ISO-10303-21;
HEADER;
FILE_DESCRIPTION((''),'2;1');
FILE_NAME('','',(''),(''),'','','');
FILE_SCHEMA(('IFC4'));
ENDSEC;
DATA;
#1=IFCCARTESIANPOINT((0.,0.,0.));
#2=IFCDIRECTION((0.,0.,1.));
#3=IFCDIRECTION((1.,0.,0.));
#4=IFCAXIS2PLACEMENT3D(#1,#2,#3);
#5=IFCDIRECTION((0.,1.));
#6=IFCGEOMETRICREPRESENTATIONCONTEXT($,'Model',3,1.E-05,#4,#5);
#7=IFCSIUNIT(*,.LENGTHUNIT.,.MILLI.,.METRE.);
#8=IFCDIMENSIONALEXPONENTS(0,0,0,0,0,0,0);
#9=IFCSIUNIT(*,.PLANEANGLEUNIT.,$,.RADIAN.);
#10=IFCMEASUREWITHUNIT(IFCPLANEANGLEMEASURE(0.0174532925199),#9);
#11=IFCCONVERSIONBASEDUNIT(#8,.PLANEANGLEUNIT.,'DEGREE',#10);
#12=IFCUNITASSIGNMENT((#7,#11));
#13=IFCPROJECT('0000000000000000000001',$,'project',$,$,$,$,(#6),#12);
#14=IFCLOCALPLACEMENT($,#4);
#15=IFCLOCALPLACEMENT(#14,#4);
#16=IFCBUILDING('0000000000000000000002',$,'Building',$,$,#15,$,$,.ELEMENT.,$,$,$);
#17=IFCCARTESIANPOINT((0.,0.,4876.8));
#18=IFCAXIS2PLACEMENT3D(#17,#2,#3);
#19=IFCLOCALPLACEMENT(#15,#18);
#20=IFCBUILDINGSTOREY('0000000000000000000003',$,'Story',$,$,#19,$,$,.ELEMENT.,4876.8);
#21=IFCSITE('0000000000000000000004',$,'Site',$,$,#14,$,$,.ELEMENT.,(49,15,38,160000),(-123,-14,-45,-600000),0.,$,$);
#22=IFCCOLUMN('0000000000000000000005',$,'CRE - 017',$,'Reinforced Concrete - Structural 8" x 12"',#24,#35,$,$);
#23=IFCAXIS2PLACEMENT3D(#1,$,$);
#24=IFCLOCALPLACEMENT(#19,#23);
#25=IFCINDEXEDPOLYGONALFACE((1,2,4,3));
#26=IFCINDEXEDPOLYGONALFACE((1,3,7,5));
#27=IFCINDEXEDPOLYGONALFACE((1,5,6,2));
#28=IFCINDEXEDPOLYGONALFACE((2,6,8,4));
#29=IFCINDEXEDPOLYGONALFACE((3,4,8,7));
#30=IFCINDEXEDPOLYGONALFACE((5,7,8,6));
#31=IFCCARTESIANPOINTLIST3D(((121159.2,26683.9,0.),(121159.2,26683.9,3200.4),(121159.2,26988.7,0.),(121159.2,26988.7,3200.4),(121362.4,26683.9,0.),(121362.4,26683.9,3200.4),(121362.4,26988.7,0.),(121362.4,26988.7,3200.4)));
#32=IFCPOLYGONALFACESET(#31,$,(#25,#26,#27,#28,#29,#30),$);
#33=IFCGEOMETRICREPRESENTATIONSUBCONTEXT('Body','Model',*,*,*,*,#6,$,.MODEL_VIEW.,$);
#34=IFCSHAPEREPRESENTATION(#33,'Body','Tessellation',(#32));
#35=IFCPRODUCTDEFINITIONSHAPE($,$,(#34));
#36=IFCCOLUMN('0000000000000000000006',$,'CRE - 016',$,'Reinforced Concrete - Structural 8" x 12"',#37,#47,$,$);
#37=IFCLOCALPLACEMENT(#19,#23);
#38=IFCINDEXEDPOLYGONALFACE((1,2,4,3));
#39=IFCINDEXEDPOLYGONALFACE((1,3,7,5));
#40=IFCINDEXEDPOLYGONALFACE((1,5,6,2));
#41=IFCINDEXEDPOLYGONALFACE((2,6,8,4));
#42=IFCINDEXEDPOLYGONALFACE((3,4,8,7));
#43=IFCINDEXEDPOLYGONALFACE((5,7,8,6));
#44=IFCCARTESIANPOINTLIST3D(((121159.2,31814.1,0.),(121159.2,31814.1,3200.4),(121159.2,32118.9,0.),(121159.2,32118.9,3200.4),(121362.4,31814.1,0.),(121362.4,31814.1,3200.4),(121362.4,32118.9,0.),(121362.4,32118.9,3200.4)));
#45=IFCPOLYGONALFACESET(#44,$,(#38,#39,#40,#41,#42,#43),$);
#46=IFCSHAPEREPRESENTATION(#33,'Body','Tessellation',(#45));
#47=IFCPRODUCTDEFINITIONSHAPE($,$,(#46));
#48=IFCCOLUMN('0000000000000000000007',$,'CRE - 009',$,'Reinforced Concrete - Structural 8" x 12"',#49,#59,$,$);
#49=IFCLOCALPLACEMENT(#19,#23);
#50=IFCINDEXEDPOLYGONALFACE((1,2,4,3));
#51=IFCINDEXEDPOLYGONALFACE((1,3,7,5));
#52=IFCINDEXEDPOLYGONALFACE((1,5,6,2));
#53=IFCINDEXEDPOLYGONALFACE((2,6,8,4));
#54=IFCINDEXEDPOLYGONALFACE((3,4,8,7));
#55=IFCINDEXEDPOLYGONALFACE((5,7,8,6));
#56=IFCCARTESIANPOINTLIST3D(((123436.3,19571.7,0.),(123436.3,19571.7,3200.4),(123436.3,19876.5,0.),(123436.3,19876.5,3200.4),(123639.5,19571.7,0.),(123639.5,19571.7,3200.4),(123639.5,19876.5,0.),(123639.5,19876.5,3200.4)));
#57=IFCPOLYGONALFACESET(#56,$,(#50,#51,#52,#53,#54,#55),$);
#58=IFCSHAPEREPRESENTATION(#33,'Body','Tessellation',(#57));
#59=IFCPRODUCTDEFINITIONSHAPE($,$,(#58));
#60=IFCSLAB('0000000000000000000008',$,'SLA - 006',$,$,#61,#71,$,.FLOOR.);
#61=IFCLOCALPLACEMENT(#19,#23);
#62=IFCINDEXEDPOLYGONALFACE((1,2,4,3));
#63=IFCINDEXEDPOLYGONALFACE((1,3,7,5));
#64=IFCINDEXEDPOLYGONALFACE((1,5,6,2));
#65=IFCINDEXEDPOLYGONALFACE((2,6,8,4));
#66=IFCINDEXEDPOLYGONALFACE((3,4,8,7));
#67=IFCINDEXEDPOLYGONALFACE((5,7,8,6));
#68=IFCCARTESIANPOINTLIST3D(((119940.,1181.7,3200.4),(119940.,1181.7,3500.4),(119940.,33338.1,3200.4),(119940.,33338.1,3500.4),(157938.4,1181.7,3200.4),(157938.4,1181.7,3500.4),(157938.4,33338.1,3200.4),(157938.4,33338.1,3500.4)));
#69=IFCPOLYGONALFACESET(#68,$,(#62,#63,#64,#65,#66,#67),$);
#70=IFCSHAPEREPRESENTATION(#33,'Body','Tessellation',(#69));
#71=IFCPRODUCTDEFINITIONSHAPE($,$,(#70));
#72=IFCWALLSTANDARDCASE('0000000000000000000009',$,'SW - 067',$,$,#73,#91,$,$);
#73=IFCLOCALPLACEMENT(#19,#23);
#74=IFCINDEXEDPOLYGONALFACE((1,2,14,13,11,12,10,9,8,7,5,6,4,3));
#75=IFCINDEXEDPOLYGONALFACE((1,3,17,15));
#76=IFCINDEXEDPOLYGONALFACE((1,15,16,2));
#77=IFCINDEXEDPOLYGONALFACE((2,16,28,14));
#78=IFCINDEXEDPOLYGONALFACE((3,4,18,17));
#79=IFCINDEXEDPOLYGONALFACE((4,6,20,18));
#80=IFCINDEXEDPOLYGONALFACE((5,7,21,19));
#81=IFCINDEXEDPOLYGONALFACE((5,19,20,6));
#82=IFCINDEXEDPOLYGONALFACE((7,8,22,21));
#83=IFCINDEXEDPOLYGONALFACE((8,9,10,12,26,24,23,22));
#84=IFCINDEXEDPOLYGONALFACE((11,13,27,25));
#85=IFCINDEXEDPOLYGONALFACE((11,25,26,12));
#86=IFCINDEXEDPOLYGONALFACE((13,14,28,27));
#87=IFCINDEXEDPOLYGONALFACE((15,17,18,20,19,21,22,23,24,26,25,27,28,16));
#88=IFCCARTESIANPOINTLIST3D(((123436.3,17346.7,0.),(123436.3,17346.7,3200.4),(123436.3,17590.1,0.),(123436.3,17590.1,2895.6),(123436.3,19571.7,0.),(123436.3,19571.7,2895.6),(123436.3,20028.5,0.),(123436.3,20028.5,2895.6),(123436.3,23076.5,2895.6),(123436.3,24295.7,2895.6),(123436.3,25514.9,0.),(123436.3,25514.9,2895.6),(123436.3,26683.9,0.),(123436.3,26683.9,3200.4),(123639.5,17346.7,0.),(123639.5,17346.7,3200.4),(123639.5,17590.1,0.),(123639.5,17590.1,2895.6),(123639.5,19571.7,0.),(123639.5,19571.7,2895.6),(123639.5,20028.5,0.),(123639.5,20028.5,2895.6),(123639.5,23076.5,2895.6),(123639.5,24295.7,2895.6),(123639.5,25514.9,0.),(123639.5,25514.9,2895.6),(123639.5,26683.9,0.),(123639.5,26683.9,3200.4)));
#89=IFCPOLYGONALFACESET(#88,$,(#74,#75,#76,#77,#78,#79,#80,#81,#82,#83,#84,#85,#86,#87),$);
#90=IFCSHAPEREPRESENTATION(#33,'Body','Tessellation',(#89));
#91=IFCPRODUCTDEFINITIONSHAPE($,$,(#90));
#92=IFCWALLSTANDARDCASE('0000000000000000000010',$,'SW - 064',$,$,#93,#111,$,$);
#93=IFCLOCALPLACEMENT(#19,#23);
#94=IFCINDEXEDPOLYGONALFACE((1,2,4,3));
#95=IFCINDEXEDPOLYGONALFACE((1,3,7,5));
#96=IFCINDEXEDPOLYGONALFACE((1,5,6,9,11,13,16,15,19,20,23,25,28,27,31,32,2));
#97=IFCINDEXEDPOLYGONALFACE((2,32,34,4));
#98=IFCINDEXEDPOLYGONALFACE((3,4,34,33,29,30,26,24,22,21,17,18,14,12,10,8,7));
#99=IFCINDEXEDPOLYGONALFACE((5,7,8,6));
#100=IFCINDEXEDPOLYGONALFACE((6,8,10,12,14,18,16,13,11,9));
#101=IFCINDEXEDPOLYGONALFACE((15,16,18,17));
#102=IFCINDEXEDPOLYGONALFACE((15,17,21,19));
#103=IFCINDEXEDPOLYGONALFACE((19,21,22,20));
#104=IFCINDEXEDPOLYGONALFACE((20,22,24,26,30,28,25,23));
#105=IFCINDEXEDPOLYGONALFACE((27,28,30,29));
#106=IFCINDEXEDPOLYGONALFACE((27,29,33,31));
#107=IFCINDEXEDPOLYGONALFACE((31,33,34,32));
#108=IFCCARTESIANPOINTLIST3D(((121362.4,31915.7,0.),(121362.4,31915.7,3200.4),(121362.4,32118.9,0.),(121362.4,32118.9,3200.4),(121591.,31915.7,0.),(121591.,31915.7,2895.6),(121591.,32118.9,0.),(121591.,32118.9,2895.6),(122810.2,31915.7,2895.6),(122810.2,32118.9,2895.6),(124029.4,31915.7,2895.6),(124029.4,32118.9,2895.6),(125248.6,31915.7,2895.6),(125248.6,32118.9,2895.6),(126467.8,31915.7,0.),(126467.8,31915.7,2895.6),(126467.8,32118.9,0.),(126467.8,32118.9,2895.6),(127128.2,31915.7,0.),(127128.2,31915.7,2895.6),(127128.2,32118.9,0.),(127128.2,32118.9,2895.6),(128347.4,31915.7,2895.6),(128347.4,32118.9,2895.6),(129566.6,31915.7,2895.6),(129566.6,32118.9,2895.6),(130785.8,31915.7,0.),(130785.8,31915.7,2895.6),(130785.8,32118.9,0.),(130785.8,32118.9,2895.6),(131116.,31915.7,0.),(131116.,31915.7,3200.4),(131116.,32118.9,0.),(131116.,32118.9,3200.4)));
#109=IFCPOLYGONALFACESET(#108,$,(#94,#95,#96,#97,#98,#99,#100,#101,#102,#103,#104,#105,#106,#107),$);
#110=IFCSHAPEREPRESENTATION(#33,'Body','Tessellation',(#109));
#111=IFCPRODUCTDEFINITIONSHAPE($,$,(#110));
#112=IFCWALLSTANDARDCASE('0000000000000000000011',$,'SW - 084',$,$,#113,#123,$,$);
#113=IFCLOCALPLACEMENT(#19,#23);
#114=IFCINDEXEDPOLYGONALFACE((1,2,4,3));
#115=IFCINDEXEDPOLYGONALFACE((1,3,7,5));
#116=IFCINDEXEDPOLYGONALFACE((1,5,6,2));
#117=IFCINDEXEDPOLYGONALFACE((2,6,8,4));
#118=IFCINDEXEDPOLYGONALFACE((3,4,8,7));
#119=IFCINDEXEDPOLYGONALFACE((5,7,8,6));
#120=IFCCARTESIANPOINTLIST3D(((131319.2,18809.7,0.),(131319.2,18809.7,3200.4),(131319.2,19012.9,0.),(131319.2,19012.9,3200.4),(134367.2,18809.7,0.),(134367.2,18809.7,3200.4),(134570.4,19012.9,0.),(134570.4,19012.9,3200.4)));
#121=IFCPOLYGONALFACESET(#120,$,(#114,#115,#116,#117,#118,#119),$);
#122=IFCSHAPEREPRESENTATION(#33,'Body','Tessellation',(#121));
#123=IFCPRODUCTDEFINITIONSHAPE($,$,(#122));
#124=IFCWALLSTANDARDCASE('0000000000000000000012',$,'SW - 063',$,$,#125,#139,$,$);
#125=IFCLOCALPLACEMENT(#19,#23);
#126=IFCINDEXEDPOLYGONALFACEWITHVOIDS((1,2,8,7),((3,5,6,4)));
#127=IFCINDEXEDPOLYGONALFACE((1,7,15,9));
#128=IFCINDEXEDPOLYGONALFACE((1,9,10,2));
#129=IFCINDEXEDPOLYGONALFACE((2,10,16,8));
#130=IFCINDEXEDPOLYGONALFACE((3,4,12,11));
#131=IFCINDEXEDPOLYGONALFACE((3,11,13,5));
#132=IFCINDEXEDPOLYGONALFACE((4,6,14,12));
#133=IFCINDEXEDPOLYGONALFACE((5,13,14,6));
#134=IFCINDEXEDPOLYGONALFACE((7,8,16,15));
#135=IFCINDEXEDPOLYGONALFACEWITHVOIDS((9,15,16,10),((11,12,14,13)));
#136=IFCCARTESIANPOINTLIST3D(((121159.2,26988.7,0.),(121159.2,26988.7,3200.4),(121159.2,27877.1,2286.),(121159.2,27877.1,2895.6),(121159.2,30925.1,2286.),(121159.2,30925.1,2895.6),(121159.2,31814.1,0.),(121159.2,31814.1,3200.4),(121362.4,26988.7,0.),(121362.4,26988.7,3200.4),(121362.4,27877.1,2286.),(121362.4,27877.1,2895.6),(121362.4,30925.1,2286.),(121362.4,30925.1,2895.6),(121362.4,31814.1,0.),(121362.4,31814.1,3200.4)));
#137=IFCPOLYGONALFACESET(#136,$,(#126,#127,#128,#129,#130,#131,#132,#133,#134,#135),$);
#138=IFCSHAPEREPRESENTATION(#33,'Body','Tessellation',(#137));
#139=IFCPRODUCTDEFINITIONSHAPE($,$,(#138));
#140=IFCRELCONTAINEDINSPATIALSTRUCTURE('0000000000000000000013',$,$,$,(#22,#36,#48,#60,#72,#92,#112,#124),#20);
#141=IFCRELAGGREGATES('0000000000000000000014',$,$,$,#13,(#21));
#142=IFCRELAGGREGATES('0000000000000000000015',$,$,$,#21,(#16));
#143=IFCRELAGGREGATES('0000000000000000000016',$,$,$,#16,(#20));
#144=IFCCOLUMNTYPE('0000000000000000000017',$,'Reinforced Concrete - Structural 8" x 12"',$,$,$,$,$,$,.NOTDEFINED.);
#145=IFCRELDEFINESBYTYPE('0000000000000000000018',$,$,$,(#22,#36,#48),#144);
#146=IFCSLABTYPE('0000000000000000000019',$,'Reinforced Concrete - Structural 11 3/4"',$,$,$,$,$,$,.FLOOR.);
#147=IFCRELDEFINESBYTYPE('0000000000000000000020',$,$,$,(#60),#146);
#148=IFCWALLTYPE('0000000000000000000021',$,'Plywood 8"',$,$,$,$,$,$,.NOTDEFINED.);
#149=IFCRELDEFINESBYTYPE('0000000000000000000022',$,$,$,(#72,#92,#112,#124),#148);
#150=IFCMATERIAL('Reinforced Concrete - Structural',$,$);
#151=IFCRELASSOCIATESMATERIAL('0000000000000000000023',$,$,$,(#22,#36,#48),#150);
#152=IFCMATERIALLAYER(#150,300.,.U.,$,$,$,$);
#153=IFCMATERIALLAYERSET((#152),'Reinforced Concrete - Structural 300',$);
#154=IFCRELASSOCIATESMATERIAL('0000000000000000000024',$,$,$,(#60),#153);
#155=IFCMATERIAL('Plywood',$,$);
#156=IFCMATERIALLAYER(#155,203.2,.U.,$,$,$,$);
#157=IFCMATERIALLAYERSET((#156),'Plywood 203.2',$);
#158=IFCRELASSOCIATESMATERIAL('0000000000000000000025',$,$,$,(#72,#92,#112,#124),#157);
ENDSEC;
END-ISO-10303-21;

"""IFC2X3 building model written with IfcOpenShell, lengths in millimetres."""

from ifc_helpers import new_model, entity, si_unit, converted_unit, direction, frame, origin_with_axes, origin_2d_with_axis, place, context, subcontext, project, spatial, polyline, rectangle, outline, extrude, material, layer, layer_set, layer_usage, type_object, element, save


model = new_model("IFC2X3")

# Units and contexts
model_context = context("Model", 3, precision=1e-05, world=origin_with_axes(), true_north=direction((0.0, 1.0)))
body_context = subcontext(model_context, "Body", "Model", "MODEL_VIEW")
ifc_project = project(units=[si_unit("LENGTHUNIT", "METRE", prefix="MILLI"), converted_unit("PLANEANGLEUNIT", "DEGREE", entity("IfcPlaneAngleMeasure", 0.0174532925199), si_unit("PLANEANGLEUNIT", "RADIAN"), dimensions=[0, 0, 0, 0, 0, 0, 0])], contexts=[model_context])

# Site, building, storey
site_placement = place(None, origin_with_axes())
site = spatial("IfcSite", under=ifc_project, at=site_placement, Name="Site", CompositionType="ELEMENT", RefLatitude=(49, 15, 38, 160000), RefLongitude=(-123, -14, -45, -600000), RefElevation=0.0)
building_placement = place(site_placement, origin_with_axes())
building = spatial("IfcBuilding", under=site, at=building_placement, Name="Building", CompositionType="ELEMENT")
storey_placement = place(building_placement, frame((0.0, 0.0, 4876.8), z_axis=(0.0, 0.0, 1.0), x_axis=(1.0, 0.0, 0.0)))
storey = spatial("IfcBuildingStorey", under=building, at=storey_placement, Name="Story", CompositionType="ELEMENT", Elevation=4876.8)

# Columns
ifc_material_1 = material(Name="Reinforced Concrete - Structural")
column_type = type_object("IfcColumnType", Name="Reinforced Concrete - Structural 8\" x 12\"", PredefinedType="NOTDEFINED")
for number, where, z_axis, x_axis, name in (
    (1, (121260.8, 26836.3, 0.0), (0.0, 0.0, 1.0), (1.0, 0.0, 0.0), "CRE - 017"),
    (2, (121260.8, 31966.5, 0.0), (0.0, 0.0, 1.0), (1.0, 0.0, 0.0), "CRE - 016"),
    (3, (123537.9, 19724.1, 0.0), (0.0, 0.0, 1.0), (1.0, 0.0, 0.0), "CRE - 009"),
):
    element("IfcColumn", number, at=place(storey_placement, frame(where, z_axis=z_axis, x_axis=x_axis)), inside=storey, type_object=column_type, material=ifc_material_1, Name=name, ObjectType="Reinforced Concrete - Structural 8\" x 12\"", context=body_context, shape_type="SweptSolid", body=[
        extrude(rectangle(XDim=203.2, YDim=304.8, at=origin_2d_with_axis()), origin_with_axes(), (0.0, 0.0, 1.0), 3200.4),
    ])

# Slab
ifc_layer_1 = layer(ifc_material_1, 300.0, ventilated="UNKNOWN")
ifc_layer_set_1 = layer_set([ifc_layer_1], Name="Reinforced Concrete - Structural 300")
ifc_layer_usage_1 = layer_usage(ifc_layer_set_1, "AXIS3", "NEGATIVE", 300.0)
slab_type = type_object("IfcSlabType", Name="Reinforced Concrete - Structural 11 3/4\"", PredefinedType="FLOOR")
slab_placement = place(storey_placement, frame((119940.0, 33338.1, 3500.4), z_axis=(0.0, 0.0, 1.0), x_axis=(1.0, 0.0, 0.0)))
element("IfcSlab", 4, at=slab_placement, inside=storey, type_object=slab_type, material=ifc_layer_usage_1, Name="SLA - 006", PredefinedType="FLOOR", context=body_context, shape_type="SweptSolid", body=[
    extrude(outline(polyline([(0.0, 0.0), (0.0, -32156.4), (37998.4, -32156.4), (37998.4, 0.0), (0.0, 0.0)])), frame((0.0, 0.0, -300.0), z_axis=(0.0, 0.0, 1.0), x_axis=(1.0, 0.0, 0.0)), (0.0, 0.0, 1.0), 300.0),
])

# Walls, openings
ifc_material_2 = material(Name="Plywood")
ifc_layer_2 = layer(ifc_material_2, 203.2, ventilated="UNKNOWN")
ifc_layer_set_2 = layer_set([ifc_layer_2], Name="Plywood 203.2")
ifc_layer_usage_2 = layer_usage(ifc_layer_set_2, "AXIS2", "NEGATIVE", 0.0)
wall_type_1 = type_object("IfcWallType", Name="Plywood 8\"", PredefinedType="NOTDEFINED")
wall_1_placement = place(storey_placement, frame((123639.5, 26887.1, 0.0), z_axis=(0.0, 0.0, 1.0), x_axis=(0.0, -1.0, 0.0)))
wall_1 = element("IfcWallStandardCase", 5, at=wall_1_placement, inside=storey, type_object=wall_type_1, material=ifc_layer_usage_2, Name="SW - 067", context=body_context, shape_type="SweptSolid", body=[
    extrude(outline(polyline([(203.2, -203.2), (9540.4, -203.2), (9540.4, 0.0), (203.2, 0.0), (203.2, -203.2)])), origin_with_axes(), (0.0, 0.0, 1.0), 3200.4),
])
opening_1_placement = place(wall_1_placement, frame((1981.7, 0.0, 0.0), z_axis=(0.0, 0.0, 1.0), x_axis=(1.0, 0.0, 0.0)))
element("IfcOpeningElement", 6, at=opening_1_placement, cuts=wall_1, context=body_context, shape_type="SweptSolid", body=[
    extrude(rectangle(XDim=1219.2, YDim=2895.6, at=origin_2d_with_axis()), frame((0.0, 203.2, 1447.8), z_axis=(0.0, -1.0, 0.0), x_axis=(-1.0, 0.0, 0.0)), (0.0, 0.0, 1.0), 609.6),
])
opening_2_placement = place(wall_1_placement, frame((3200.9, 0.0, 0.0), z_axis=(0.0, 0.0, 1.0), x_axis=(1.0, 0.0, 0.0)))
element("IfcOpeningElement", 7, at=opening_2_placement, cuts=wall_1, context=body_context, shape_type="SweptSolid", body=[
    extrude(rectangle(XDim=1219.2, YDim=2895.6, at=origin_2d_with_axis()), frame((0.0, 203.2, 1447.8), z_axis=(0.0, -1.0, 0.0), x_axis=(-1.0, 0.0, 0.0)), (0.0, 0.0, 1.0), 609.6),
])
opening_3_placement = place(wall_1_placement, frame((8306.2, 0.0, 0.0), z_axis=(0.0, 0.0, 1.0), x_axis=(1.0, 0.0, 0.0)))
element("IfcOpeningElement", 8, at=opening_3_placement, cuts=wall_1, context=body_context, shape_type="SweptSolid", body=[
    extrude(rectangle(XDim=1981.5, YDim=2895.6, at=origin_2d_with_axis()), frame((0.0, 203.2, 1447.8), z_axis=(0.0, -1.0, 0.0), x_axis=(-1.0, 0.0, 0.0)), (0.0, 0.0, 1.0), 609.6),
])
opening_4_placement = place(wall_1_placement, frame((5334.5, 0.0, 0.0), z_axis=(0.0, 0.0, 1.0), x_axis=(1.0, 0.0, 0.0)))
element("IfcOpeningElement", 9, at=opening_4_placement, cuts=wall_1, context=body_context, shape_type="SweptSolid", body=[
    extrude(rectangle(XDim=3048.0, YDim=2895.6, at=origin_2d_with_axis()), frame((0.0, 203.2, 1447.8), z_axis=(0.0, -1.0, 0.0), x_axis=(-1.0, 0.0, 0.0)), (0.0, 0.0, 1.0), 609.6),
])
ifc_layer_usage_3 = layer_usage(ifc_layer_set_2, "AXIS2", "POSITIVE", 0.0)
wall_2_placement = place(storey_placement, frame((121362.4, 31915.7, 0.0), z_axis=(0.0, 0.0, 1.0), x_axis=(1.0, 0.0, 0.0)))
wall_2 = element("IfcWallStandardCase", 10, at=wall_2_placement, inside=storey, type_object=wall_type_1, material=ifc_layer_usage_3, Name="SW - 064", context=body_context, shape_type="SweptSolid", body=[
    extrude(outline(polyline([(0.0, 0.0), (9753.6, 0.0), (9753.6, 203.2), (0.0, 203.2), (0.0, 0.0)])), origin_with_axes(), (0.0, 0.0, 1.0), 3200.4),
])
opening_5_placement = place(wall_2_placement, frame((8813.8, 0.0, 0.0), z_axis=(0.0, 0.0, 1.0), x_axis=(1.0, 0.0, 0.0)))
element("IfcOpeningElement", 11, at=opening_5_placement, cuts=wall_2, context=body_context, shape_type="SweptSolid", body=[
    extrude(rectangle(XDim=1219.2, YDim=2895.6, at=origin_2d_with_axis()), frame((0.0, -203.2, 1447.8), z_axis=(0.0, -1.0, 0.0), x_axis=(-1.0, 0.0, 0.0)), (0.0, 0.0, -1.0), 609.6),
])
opening_6_placement = place(wall_2_placement, frame((7594.6, 0.0, 0.0), z_axis=(0.0, 0.0, 1.0), x_axis=(1.0, 0.0, 0.0)))
element("IfcOpeningElement", 12, at=opening_6_placement, cuts=wall_2, context=body_context, shape_type="SweptSolid", body=[
    extrude(rectangle(XDim=1219.2, YDim=2895.6, at=origin_2d_with_axis()), frame((0.0, -203.2, 1447.8), z_axis=(0.0, -1.0, 0.0), x_axis=(-1.0, 0.0, 0.0)), (0.0, 0.0, -1.0), 609.6),
])
opening_7_placement = place(wall_2_placement, frame((6375.4, 0.0, 0.0), z_axis=(0.0, 0.0, 1.0), x_axis=(1.0, 0.0, 0.0)))
element("IfcOpeningElement", 13, at=opening_7_placement, cuts=wall_2, context=body_context, shape_type="SweptSolid", body=[
    extrude(rectangle(XDim=1219.2, YDim=2895.6, at=origin_2d_with_axis()), frame((0.0, -203.2, 1447.8), z_axis=(0.0, 1.0, 0.0), x_axis=(1.0, 0.0, 0.0)), (0.0, 0.0, 1.0), 609.6),
])
opening_8_placement = place(wall_2_placement, frame((4495.8, 0.0, 0.0), z_axis=(0.0, 0.0, 1.0), x_axis=(1.0, 0.0, 0.0)))
element("IfcOpeningElement", 14, at=opening_8_placement, cuts=wall_2, context=body_context, shape_type="SweptSolid", body=[
    extrude(rectangle(XDim=1219.2, YDim=2895.6, at=origin_2d_with_axis()), frame((0.0, -203.2, 1447.8), z_axis=(0.0, -1.0, 0.0), x_axis=(-1.0, 0.0, 0.0)), (0.0, 0.0, -1.0), 609.6),
])
opening_9_placement = place(wall_2_placement, frame((3276.6, 0.0, 0.0), z_axis=(0.0, 0.0, 1.0), x_axis=(1.0, 0.0, 0.0)))
element("IfcOpeningElement", 15, at=opening_9_placement, cuts=wall_2, context=body_context, shape_type="SweptSolid", body=[
    extrude(rectangle(XDim=1219.2, YDim=2895.6, at=origin_2d_with_axis()), frame((0.0, -203.2, 1447.8), z_axis=(0.0, -1.0, 0.0), x_axis=(-1.0, 0.0, 0.0)), (0.0, 0.0, -1.0), 609.6),
])
opening_10_placement = place(wall_2_placement, frame((2057.4, 0.0, 0.0), z_axis=(0.0, 0.0, 1.0), x_axis=(1.0, 0.0, 0.0)))
element("IfcOpeningElement", 16, at=opening_10_placement, cuts=wall_2, context=body_context, shape_type="SweptSolid", body=[
    extrude(rectangle(XDim=1219.2, YDim=2895.6, at=origin_2d_with_axis()), frame((0.0, -203.2, 1447.8), z_axis=(0.0, -1.0, 0.0), x_axis=(-1.0, 0.0, 0.0)), (0.0, 0.0, -1.0), 609.6),
])
opening_11_placement = place(wall_2_placement, frame((838.2, 0.0, 0.0), z_axis=(0.0, 0.0, 1.0), x_axis=(1.0, 0.0, 0.0)))
element("IfcOpeningElement", 17, at=opening_11_placement, cuts=wall_2, context=body_context, shape_type="SweptSolid", body=[
    extrude(rectangle(XDim=1219.2, YDim=2895.6, at=origin_2d_with_axis()), frame((0.0, -203.2, 1447.8), z_axis=(0.0, 1.0, 0.0), x_axis=(1.0, 0.0, 0.0)), (0.0, 0.0, 1.0), 609.6),
])

# Wall
ifc_layer_usage_4 = layer_usage(ifc_layer_set_2, "AXIS2", "NEGATIVE", 0.0)
wall_3_placement = place(storey_placement, frame((131116.0, 19012.9, 0.0), z_axis=(0.0, 0.0, 1.0), x_axis=(1.0, 0.0, 0.0)))
element("IfcWallStandardCase", 18, at=wall_3_placement, inside=storey, type_object=wall_type_1, material=ifc_layer_usage_4, Name="SW - 084", context=body_context, shape_type="SweptSolid", body=[
    extrude(outline(polyline([(203.2, -203.2), (3251.2, -203.2), (3454.4, 0.0), (203.2, 0.0), (203.2, -203.2)])), origin_with_axes(), (0.0, 0.0, 1.0), 3200.4),
])

# Wall, opening
ifc_layer_usage_5 = layer_usage(ifc_layer_set_2, "AXIS2", "POSITIVE", 0.0)
wall_4_placement = place(storey_placement, frame((121362.4, 26988.7, 0.0), z_axis=(0.0, 0.0, 1.0), x_axis=(0.0, 1.0, 0.0)))
wall_4 = element("IfcWallStandardCase", 19, at=wall_4_placement, inside=storey, type_object=wall_type_1, material=ifc_layer_usage_5, Name="SW - 063", context=body_context, shape_type="SweptSolid", body=[
    extrude(outline(polyline([(0.0, 0.0), (4825.5, 0.0), (4825.5, 203.2), (0.0, 203.2), (0.0, 0.0)])), origin_with_axes(), (0.0, 0.0, 1.0), 3200.4),
])
opening_12_placement = place(wall_4_placement, frame((2412.5, 0.0, 2286.0), z_axis=(0.0, 0.0, 1.0), x_axis=(1.0, 0.0, 0.0)))
element("IfcOpeningElement", 20, at=opening_12_placement, cuts=wall_4, context=body_context, shape_type="SweptSolid", body=[
    extrude(rectangle(XDim=3048.0, YDim=609.6, at=origin_2d_with_axis()), frame((0.0, -203.2, 304.8), z_axis=(0.0, 1.0, 0.0), x_axis=(1.0, 0.0, 0.0)), (0.0, 0.0, 1.0), 609.6),
])

save(model, "model.ifc")
